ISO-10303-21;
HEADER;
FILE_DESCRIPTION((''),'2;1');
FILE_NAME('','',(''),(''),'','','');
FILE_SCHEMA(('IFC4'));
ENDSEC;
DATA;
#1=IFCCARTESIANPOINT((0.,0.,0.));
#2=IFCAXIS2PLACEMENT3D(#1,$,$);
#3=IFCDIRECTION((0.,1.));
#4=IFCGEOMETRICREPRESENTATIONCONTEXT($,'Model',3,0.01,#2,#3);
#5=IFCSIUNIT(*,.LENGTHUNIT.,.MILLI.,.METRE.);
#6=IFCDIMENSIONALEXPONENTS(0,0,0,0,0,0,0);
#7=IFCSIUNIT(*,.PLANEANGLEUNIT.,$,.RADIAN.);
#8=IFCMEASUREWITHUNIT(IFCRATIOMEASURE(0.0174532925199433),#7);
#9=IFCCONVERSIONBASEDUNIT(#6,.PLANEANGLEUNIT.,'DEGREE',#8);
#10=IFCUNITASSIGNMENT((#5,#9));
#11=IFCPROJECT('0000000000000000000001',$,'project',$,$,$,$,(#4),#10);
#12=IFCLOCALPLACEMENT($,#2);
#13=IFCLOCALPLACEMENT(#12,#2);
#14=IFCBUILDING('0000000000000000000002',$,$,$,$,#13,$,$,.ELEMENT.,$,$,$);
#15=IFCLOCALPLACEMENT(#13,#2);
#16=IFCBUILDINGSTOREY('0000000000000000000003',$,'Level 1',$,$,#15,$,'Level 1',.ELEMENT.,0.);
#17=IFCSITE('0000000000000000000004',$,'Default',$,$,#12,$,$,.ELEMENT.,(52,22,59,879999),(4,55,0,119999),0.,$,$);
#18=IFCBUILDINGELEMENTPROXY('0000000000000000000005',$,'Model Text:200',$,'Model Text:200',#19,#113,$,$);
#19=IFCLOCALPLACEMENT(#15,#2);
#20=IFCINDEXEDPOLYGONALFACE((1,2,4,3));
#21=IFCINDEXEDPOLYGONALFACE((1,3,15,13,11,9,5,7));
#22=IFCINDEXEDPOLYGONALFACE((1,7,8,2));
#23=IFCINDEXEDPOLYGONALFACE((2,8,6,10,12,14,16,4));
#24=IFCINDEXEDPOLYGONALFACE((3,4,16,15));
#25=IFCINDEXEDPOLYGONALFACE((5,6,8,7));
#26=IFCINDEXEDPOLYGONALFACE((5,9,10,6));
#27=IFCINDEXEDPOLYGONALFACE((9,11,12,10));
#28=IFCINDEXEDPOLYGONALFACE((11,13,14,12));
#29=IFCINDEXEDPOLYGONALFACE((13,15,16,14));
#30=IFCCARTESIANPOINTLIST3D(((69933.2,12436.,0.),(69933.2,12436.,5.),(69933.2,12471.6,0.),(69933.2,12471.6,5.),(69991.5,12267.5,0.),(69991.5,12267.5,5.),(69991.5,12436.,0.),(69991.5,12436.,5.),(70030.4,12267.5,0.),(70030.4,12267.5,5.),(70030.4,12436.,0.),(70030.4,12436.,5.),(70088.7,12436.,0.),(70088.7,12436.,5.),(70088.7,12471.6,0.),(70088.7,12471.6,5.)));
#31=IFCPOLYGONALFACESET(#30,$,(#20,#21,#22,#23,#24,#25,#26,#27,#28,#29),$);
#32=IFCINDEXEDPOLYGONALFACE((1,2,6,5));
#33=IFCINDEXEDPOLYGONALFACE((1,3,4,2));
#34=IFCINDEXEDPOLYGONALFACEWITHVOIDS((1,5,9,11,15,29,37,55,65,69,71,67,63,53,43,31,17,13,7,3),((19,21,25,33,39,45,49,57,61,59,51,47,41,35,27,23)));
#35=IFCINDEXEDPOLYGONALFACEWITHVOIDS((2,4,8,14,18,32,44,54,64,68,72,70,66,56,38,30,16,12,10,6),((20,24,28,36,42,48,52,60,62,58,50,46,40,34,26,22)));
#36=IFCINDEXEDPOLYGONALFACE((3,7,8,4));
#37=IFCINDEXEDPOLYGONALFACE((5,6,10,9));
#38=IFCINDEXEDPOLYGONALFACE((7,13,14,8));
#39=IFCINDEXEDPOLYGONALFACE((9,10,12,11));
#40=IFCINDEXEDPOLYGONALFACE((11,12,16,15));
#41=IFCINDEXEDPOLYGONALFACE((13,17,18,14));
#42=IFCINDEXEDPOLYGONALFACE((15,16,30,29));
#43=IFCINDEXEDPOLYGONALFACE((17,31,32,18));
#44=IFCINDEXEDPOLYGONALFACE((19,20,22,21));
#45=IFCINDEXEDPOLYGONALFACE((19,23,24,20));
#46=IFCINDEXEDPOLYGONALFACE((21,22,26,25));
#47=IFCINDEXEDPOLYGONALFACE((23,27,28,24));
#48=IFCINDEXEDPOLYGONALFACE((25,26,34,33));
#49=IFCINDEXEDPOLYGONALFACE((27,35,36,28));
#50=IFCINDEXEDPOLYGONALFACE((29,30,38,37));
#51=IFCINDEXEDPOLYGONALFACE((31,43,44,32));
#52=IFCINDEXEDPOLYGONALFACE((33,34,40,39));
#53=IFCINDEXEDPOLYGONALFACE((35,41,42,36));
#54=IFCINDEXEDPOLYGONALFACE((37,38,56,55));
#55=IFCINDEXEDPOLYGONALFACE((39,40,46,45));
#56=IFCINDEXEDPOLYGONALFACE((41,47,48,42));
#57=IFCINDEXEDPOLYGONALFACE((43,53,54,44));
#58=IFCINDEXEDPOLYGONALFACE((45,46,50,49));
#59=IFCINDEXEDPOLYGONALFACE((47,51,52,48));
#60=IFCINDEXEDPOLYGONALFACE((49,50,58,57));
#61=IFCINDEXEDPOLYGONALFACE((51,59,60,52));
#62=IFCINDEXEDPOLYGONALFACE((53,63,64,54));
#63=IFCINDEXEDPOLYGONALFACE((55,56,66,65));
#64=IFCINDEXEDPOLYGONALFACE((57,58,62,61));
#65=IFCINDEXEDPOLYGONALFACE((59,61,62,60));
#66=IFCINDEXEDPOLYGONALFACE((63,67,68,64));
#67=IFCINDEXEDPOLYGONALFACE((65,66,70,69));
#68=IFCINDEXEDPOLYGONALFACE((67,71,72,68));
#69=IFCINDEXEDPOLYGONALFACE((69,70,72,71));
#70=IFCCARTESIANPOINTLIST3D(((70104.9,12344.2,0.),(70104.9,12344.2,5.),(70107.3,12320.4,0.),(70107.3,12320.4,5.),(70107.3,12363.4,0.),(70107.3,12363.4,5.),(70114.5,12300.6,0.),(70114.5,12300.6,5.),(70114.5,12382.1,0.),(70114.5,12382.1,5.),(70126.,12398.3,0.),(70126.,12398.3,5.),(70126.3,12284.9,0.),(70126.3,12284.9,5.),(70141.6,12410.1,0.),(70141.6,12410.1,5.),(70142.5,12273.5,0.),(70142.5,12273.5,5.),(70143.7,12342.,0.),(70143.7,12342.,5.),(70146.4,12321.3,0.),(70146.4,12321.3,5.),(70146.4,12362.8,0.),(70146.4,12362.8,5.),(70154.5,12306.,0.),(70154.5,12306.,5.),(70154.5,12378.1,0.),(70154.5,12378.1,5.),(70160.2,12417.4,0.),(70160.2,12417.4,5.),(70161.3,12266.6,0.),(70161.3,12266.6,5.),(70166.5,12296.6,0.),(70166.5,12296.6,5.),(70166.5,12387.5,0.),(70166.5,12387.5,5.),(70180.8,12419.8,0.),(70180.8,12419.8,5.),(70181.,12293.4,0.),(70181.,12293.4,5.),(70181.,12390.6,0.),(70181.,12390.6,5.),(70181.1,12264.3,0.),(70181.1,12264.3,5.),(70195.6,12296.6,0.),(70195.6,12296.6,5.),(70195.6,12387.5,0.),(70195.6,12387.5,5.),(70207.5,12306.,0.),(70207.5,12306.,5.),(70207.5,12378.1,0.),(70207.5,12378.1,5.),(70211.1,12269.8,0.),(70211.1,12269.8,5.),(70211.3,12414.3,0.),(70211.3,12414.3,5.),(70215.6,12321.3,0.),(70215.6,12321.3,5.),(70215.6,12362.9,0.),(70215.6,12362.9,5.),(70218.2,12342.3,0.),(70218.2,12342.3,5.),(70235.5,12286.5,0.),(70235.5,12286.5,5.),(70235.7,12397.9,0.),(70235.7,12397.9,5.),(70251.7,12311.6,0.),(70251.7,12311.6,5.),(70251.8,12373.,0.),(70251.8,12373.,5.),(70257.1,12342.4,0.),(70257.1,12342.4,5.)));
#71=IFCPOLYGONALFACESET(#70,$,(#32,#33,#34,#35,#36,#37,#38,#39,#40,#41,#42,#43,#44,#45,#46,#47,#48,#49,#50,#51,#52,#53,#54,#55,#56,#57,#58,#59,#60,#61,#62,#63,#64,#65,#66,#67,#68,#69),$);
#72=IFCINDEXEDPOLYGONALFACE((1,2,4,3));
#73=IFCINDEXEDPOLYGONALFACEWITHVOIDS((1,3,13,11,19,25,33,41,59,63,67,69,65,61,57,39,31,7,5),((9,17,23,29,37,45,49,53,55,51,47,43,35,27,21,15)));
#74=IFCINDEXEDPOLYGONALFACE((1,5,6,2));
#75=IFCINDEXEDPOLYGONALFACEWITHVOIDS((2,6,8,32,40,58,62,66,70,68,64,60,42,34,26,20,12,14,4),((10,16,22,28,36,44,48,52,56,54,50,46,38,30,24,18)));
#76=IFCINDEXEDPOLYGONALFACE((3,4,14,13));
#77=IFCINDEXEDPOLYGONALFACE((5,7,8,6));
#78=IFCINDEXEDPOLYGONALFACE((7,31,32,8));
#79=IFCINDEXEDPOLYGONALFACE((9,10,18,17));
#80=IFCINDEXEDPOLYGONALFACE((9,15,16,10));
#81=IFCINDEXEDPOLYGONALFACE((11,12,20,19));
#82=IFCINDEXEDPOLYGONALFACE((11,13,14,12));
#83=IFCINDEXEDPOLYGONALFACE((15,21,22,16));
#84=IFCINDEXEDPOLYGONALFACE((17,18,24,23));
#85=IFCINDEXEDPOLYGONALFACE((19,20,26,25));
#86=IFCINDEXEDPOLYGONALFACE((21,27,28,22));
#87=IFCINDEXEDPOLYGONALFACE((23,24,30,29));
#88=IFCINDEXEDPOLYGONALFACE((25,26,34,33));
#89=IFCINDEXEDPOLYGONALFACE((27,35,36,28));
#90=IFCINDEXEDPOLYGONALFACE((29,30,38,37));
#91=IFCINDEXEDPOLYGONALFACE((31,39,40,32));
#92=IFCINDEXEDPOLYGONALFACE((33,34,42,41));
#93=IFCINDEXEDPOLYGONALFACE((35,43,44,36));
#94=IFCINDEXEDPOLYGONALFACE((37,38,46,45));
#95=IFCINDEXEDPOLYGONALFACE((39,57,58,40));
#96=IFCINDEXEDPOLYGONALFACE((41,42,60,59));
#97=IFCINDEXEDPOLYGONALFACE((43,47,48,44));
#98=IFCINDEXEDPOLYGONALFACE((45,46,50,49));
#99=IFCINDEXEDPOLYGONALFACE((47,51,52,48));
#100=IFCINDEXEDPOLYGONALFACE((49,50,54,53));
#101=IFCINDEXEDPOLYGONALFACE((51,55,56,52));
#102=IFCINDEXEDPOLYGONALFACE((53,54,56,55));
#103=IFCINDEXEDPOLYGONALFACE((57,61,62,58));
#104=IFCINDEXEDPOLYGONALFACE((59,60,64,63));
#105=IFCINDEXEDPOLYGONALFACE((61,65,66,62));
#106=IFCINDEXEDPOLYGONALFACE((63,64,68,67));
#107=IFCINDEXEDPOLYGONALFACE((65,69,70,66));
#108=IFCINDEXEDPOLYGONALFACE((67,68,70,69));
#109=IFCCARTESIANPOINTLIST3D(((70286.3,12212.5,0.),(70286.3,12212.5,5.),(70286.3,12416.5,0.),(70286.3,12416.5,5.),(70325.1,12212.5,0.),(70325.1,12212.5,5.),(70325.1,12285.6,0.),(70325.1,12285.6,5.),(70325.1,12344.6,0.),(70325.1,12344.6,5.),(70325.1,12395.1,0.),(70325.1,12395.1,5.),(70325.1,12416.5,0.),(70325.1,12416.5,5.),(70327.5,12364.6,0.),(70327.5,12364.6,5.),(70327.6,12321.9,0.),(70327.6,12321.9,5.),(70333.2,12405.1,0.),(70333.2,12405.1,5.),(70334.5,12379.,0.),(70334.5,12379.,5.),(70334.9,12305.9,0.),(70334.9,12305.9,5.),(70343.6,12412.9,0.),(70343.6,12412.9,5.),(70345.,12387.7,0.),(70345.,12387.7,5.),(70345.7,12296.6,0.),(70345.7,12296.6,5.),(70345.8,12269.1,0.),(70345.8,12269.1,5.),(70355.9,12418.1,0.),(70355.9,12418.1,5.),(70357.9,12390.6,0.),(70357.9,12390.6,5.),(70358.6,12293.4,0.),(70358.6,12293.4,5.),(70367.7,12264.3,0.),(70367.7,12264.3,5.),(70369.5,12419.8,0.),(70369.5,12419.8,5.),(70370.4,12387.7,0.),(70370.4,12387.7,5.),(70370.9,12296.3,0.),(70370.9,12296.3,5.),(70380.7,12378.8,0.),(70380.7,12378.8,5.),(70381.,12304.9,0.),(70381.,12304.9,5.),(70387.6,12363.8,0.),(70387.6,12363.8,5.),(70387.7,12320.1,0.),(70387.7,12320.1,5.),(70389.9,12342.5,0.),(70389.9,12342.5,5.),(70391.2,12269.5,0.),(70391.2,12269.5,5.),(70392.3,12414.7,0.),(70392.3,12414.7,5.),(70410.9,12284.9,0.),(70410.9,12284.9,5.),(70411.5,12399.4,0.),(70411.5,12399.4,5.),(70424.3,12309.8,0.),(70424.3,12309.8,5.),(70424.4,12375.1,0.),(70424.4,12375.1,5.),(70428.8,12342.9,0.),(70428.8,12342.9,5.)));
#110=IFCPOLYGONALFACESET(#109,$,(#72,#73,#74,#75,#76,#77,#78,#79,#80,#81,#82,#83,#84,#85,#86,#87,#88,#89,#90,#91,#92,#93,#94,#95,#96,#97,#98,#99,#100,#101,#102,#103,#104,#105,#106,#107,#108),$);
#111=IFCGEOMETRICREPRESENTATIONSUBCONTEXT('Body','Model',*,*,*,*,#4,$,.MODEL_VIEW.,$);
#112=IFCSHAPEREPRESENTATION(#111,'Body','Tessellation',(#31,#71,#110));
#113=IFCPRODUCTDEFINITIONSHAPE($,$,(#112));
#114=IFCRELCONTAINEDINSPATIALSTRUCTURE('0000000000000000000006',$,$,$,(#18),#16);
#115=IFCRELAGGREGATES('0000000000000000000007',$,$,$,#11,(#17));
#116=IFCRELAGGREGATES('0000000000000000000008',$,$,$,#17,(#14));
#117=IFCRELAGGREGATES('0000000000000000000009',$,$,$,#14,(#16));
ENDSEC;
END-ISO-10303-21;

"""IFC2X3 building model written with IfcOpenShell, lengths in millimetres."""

from ifc_helpers import new_model, entity, si_unit, converted_unit, direction, frame, origin, place, context, subcontext, project, spatial, polyline, outline, extrude, element, save


model = new_model("IFC2X3")

# Units and contexts
model_context = context("Model", 3, precision=0.01, world=origin(), true_north=direction((0.0, 1.0)))
body_context = subcontext(model_context, "Body", "Model", "MODEL_VIEW")
ifc_project = project(units=[si_unit("LENGTHUNIT", "METRE", prefix="MILLI"), converted_unit("PLANEANGLEUNIT", "DEGREE", entity("IfcRatioMeasure", 0.0174532925199433), si_unit("PLANEANGLEUNIT", "RADIAN"), dimensions=[0, 0, 0, 0, 0, 0, 0])], contexts=[model_context])

# Site, building, storey
site_placement = place(None, origin())
site = spatial("IfcSite", under=ifc_project, at=site_placement, Name="Default", CompositionType="ELEMENT", RefLatitude=(52, 22, 59, 879999), RefLongitude=(4, 55, 0, 119999), RefElevation=0.0)
building_placement = place(site_placement, origin())
building = spatial("IfcBuilding", under=site, at=building_placement, CompositionType="ELEMENT")
storey_placement = place(building_placement, origin())
storey = spatial("IfcBuildingStorey", under=building, at=storey_placement, Name="Level 1", LongName="Level 1", CompositionType="ELEMENT", Elevation=0.0)

# Building element proxy
proxy_1_placement = place(building_placement, origin())
element("IfcBuildingElementProxy", 1, at=proxy_1_placement, inside=storey, Name="Model Text:200", ObjectType="Model Text:200", context=body_context, shape_type="SweptSolid", body=[
    extrude(outline(polyline([(-19.4, -135.2), (19.4, -135.2), (19.4, 33.2), (77.7, 33.2), (77.7, 68.8), (-77.7, 68.8), (-77.7, 33.2), (-19.4, 33.2), (-19.4, -135.2)])), frame((70010.9, 12402.8, 0.0)), (0.0, 0.0, 1.0), 5.0),
    extrude(outline(polyline([(-8.8, -65.7), (15.1, -65.7), (35.5, -60.5), (52.3, -50.4), (65.3, -35.4), (74.1, -17.3), (78.4, 2.1), (75.9, 32.5), (61.8, 58.5), (38.4, 77.1), (8.3, 85.6), (-22.7, 83.3), (-49.0, 69.9), (-67.8, 47.3), (-76.3, 17.5), (-76.0, -3.3), (-70.7, -22.5), (-60.5, -39.2), (-45.5, -52.3), (-27.7, -61.4), (-8.8, -65.7)]), holes=[polyline([(-2.7, -27.2), (-23.1, -22.5), (-37.5, -12.9), (-45.7, 0.0), (-47.3, 14.8), (-42.7, 28.9), (-32.2, 39.9), (-16.3, 46.3), (4.5, 46.9), (25.1, 42.1), (39.6, 32.6), (47.7, 19.7), (49.4, 5.0), (44.8, -9.2), (34.2, -20.2), (18.2, -26.7), (-2.7, -27.2)])]), frame((70171.1, 12342.1, 0.0), z_axis=(0.0, 0.0, 1.0), x_axis=(0.100608, -0.994926, 0.0)), (0.0, 0.0, 1.0), 5.0),
    extrude(outline(polyline([(-73.1, -75.4), (130.9, -75.4), (130.9, -36.6), (57.8, -36.6), (74.3, -15.9), (79.1, 6.0), (73.9, 29.5), (58.4, 49.2), (33.6, 62.6), (0.5, 67.1), (-31.8, 62.8), (-56.1, 49.8), (-71.3, 30.7), (-76.4, 7.8), (-74.7, -5.8), (-69.6, -18.1), (-61.7, -28.5), (-51.7, -36.6), (-73.1, -36.6), (-73.1, -75.4)]), holes=[polyline([(-1.2, -36.6), (-21.2, -34.2), (-35.6, -27.2), (-44.3, -16.7), (-47.2, -3.8), (-44.3, 8.7), (-35.4, 19.0), (-20.4, 25.9), (0.8, 28.2), (23.3, 26.0), (38.5, 19.3), (47.1, 9.2), (49.9, -3.1), (46.8, -16.0), (37.4, -26.8), (21.5, -34.1), (-1.2, -36.6)])]), frame((70361.7, 12343.4, 0.0), z_axis=(0.0, 0.0, 1.0), x_axis=(0.0, -1.0, 0.0)), (0.0, 0.0, 1.0), 5.0),
])

save(model, "model.ifc")
